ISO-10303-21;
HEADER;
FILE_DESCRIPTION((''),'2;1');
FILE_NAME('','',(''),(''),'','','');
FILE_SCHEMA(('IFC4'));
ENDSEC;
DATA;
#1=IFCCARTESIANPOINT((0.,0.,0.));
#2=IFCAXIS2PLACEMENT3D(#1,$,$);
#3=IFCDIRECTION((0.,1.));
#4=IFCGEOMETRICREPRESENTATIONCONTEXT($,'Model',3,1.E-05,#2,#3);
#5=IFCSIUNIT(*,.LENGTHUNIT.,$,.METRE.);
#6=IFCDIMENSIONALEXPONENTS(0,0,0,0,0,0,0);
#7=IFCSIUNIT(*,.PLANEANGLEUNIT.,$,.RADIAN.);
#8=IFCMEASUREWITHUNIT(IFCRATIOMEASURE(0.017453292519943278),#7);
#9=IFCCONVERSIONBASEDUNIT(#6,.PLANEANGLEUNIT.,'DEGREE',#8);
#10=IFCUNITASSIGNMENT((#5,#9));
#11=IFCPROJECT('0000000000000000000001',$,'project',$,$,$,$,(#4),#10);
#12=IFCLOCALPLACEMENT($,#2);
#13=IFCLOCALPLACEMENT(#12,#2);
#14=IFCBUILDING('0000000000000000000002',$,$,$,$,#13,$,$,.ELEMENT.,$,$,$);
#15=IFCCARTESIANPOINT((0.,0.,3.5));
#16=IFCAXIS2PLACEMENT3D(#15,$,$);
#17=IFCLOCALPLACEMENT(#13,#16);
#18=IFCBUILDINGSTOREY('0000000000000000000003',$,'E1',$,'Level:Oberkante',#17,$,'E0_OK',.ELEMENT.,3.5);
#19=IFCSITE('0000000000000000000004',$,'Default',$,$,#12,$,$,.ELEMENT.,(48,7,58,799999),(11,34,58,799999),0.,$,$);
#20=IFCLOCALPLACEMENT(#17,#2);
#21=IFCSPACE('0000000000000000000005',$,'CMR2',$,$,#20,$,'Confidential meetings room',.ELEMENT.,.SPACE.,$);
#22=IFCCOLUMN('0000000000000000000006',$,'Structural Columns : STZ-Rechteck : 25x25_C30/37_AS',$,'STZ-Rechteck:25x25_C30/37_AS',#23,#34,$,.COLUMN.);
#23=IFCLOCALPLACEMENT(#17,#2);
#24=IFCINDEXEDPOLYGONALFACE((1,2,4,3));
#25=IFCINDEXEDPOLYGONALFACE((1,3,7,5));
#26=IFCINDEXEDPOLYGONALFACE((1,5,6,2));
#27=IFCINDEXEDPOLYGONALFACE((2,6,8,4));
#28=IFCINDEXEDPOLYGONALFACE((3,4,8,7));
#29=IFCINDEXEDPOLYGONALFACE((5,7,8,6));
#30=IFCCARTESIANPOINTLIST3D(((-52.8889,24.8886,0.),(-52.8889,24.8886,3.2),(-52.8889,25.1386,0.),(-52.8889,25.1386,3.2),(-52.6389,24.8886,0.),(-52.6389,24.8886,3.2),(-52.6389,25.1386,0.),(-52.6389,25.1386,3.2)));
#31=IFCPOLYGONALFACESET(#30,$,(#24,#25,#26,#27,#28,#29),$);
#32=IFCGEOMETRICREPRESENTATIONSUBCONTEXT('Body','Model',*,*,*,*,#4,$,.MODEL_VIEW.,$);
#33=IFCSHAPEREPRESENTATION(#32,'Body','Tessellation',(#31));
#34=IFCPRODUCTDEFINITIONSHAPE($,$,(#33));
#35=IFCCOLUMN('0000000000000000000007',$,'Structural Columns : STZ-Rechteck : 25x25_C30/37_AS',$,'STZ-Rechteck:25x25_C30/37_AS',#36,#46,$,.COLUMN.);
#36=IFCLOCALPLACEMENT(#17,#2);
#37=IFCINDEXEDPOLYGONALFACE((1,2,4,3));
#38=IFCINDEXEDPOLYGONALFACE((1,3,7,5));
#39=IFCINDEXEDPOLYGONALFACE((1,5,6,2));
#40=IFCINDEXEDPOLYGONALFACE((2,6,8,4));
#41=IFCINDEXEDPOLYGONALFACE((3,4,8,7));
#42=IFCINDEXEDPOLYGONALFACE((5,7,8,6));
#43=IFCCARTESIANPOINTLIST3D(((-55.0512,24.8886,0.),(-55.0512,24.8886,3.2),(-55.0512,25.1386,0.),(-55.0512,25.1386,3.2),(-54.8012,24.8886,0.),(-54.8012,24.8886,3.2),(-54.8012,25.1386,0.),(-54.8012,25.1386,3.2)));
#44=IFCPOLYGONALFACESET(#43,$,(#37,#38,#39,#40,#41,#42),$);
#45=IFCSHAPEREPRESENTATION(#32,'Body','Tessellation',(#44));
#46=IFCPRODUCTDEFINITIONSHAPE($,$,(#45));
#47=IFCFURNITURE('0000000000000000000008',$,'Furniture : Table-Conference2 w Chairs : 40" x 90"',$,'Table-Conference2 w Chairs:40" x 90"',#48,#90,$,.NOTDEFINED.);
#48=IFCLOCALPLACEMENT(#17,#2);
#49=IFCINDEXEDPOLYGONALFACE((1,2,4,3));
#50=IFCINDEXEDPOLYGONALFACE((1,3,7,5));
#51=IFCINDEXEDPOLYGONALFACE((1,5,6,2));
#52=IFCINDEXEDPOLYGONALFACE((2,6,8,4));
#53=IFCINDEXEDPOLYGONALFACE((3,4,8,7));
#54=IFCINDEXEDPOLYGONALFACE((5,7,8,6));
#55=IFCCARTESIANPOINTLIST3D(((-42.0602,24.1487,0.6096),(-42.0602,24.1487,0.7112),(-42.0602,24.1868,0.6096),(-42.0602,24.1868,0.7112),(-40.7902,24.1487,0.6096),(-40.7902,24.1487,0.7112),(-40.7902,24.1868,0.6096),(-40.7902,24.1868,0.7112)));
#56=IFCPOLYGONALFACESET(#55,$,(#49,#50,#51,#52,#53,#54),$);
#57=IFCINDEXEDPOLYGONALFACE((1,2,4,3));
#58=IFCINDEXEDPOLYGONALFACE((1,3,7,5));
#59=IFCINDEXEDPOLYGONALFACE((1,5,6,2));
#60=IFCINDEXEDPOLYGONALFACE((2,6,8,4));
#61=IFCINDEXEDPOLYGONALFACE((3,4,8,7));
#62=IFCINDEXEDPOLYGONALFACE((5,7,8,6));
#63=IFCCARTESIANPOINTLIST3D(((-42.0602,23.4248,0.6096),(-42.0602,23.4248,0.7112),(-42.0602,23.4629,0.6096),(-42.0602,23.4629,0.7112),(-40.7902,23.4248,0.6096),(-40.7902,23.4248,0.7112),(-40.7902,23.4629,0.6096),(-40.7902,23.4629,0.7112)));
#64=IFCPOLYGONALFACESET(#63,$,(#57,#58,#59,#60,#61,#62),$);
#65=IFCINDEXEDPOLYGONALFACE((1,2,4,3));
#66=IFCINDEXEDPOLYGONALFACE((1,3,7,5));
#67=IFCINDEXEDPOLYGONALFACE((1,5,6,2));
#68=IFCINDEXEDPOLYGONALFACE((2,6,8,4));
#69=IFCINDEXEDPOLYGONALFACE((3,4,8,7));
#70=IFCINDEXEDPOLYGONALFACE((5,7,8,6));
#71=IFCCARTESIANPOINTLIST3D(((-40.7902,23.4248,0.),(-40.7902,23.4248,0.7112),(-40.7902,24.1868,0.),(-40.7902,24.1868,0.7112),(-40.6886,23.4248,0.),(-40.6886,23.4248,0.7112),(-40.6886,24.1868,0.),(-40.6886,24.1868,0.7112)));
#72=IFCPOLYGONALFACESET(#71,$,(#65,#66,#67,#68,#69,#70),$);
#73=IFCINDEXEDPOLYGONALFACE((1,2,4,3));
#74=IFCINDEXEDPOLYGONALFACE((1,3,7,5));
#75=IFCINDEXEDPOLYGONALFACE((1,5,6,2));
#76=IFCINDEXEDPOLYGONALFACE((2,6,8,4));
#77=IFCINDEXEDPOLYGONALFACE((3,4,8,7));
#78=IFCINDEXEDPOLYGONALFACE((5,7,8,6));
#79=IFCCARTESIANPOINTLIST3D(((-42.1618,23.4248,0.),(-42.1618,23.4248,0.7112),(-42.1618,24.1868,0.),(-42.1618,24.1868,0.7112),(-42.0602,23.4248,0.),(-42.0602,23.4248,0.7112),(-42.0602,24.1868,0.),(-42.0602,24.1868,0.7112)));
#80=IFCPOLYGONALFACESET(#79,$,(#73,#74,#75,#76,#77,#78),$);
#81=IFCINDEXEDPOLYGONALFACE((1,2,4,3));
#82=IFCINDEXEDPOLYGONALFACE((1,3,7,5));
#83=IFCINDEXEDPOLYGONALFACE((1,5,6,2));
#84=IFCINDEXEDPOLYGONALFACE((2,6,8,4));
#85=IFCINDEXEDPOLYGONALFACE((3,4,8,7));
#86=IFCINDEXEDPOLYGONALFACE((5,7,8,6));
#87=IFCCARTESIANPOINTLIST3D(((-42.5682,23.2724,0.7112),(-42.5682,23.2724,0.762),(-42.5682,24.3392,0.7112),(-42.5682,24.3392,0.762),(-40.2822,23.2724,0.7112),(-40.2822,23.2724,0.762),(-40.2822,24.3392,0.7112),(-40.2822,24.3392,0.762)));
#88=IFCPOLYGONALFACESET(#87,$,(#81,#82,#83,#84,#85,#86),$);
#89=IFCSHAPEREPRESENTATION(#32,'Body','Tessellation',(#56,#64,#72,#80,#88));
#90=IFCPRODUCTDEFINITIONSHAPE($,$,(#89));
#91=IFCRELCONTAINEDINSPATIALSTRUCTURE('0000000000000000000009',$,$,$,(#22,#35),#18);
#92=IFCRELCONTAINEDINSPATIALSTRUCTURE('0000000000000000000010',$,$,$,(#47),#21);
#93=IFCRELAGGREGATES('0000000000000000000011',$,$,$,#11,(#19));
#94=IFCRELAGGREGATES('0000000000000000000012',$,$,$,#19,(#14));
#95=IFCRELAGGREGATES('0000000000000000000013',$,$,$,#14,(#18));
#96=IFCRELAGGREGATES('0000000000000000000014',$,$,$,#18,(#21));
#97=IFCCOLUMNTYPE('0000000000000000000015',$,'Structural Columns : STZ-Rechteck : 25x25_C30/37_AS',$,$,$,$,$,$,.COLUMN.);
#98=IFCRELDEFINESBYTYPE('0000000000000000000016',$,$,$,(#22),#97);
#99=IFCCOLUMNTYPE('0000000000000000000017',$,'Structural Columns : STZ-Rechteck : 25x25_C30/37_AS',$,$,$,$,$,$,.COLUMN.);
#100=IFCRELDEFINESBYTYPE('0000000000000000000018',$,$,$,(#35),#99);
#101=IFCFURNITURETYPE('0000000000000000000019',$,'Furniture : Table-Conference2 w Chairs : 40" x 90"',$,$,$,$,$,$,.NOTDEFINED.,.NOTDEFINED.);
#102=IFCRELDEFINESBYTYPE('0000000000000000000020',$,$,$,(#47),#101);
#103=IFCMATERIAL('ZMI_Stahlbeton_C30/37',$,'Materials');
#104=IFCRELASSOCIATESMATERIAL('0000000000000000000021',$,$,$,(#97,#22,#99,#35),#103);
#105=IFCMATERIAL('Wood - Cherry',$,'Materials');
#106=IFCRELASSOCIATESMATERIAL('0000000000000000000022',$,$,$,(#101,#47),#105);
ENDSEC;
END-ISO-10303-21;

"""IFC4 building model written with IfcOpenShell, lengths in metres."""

from ifc_helpers import new_model, entity, si_unit, converted_unit, direction, frame, origin, place, context, subcontext, project, spatial, indexed_curve, outline, extrude, source, transform, mapped, material, type_object, type_shapes, element, save


model = new_model("IFC4")

# Units and contexts
model_context = context("Model", 3, precision=1e-05, world=origin(), true_north=direction((0.0, 1.0)))
body_context = subcontext(model_context, "Body", "Model", "MODEL_VIEW")
ifc_project = project(units=[si_unit("LENGTHUNIT", "METRE"), converted_unit("PLANEANGLEUNIT", "DEGREE", entity("IfcRatioMeasure", 0.017453292519943278), si_unit("PLANEANGLEUNIT", "RADIAN"), dimensions=[0, 0, 0, 0, 0, 0, 0])], contexts=[model_context])

# Site, building, storey
site_placement = place(None, origin())
site = spatial("IfcSite", under=ifc_project, at=site_placement, Name="Default", CompositionType="ELEMENT", RefLatitude=(48, 7, 58, 799999), RefLongitude=(11, 34, 58, 799999), RefElevation=0.0)
building_placement = place(site_placement, origin())
building = spatial("IfcBuilding", under=site, at=building_placement, CompositionType="ELEMENT")
storey_placement = place(building_placement, frame((0.0, 0.0, 3.5)))
storey = spatial("IfcBuildingStorey", under=building, at=storey_placement, Name="E1", ObjectType="Level:Oberkante", LongName="E0_OK", CompositionType="ELEMENT", Elevation=3.5)

# Columns
ifc_material_1 = material(Name="ZMI_Stahlbeton_C30/37", Category="Materials")
column_type_1 = type_object("IfcColumnType", Name="Structural Columns : STZ-Rechteck : 25x25_C30/37_AS", PredefinedType="COLUMN", material=ifc_material_1)
shared_shape_1 = source(origin(), body_context, "Body", "SweptSolid", [
    extrude(outline(indexed_curve([(-0.125, -0.125), (0.125, -0.125), (0.125, 0.125), (-0.125, 0.125), (-0.125, -0.125)], self_intersect=False)), frame((-52.7639, 25.0136, 3.5), z_axis=(0.0, 0.0, 1.0), x_axis=(0.0, -1.0, 0.0)), (0.0, 0.0, 1.0), 3.2),
])
type_shapes(column_type_1, [shared_shape_1])
column_1_placement = place(storey_placement, frame((0.0, 0.0, -3.5)))
element("IfcColumn", 1, at=column_1_placement, inside=storey, type_object=column_type_1, material=ifc_material_1, Name="Structural Columns : STZ-Rechteck : 25x25_C30/37_AS", ObjectType="STZ-Rechteck:25x25_C30/37_AS", PredefinedType="COLUMN", context=body_context, shape_type="MappedRepresentation", body=[
    mapped(shared_shape_1, transform((0.0, 0.0, 0.0), scale=1.0)),
])
column_type_2 = type_object("IfcColumnType", Name="Structural Columns : STZ-Rechteck : 25x25_C30/37_AS", PredefinedType="COLUMN", material=ifc_material_1)
shared_shape_2 = source(origin(), body_context, "Body", "SweptSolid", [
    extrude(outline(indexed_curve([(-0.125, -0.125), (0.125, -0.125), (0.125, 0.125), (-0.125, 0.125), (-0.125, -0.125)], self_intersect=False)), frame((-54.9262, 25.0136, 3.5), z_axis=(0.0, 0.0, 1.0), x_axis=(0.0, -1.0, 0.0)), (0.0, 0.0, 1.0), 3.2),
])
type_shapes(column_type_2, [shared_shape_2])
column_2_placement = place(storey_placement, frame((0.0, 0.0, -3.5)))
element("IfcColumn", 2, at=column_2_placement, inside=storey, type_object=column_type_2, material=ifc_material_1, Name="Structural Columns : STZ-Rechteck : 25x25_C30/37_AS", ObjectType="STZ-Rechteck:25x25_C30/37_AS", PredefinedType="COLUMN", context=body_context, shape_type="MappedRepresentation", body=[
    mapped(shared_shape_2, transform((0.0, 0.0, 0.0), scale=1.0)),
])

# Shared definitions
space_placement = place(storey_placement, origin())
space = spatial("IfcSpace", under=storey, at=space_placement, Name="CMR2", LongName="Confidential meetings room", CompositionType="ELEMENT", PredefinedType="SPACE")

# Furniture
ifc_material_2 = material(Name="Wood - Cherry", Category="Materials")
furniture_type_1 = type_object("IfcFurnitureType", Name="Furniture : Table-Conference2 w Chairs : 40\" x 90\"", AssemblyPlace="NOTDEFINED", PredefinedType="NOTDEFINED", material=ifc_material_2)
shared_shape_3 = source(origin(), body_context, "Body", "SweptSolid", [
    extrude(outline(indexed_curve([(-0.635, -0.0191), (0.635, -0.0191), (0.635, 0.0191), (-0.635, 0.0191), (-0.635, -0.0191)], self_intersect=False)), frame((0.0, 0.362, 0.6096), z_axis=(0.0, 0.0, 1.0), x_axis=(-1.0, 0.0, 0.0)), (0.0, 0.0, 1.0), 0.1016),
    extrude(outline(indexed_curve([(-0.019, -0.635), (0.019, -0.635), (0.019, 0.635), (-0.019, 0.635), (-0.019, -0.635)], self_intersect=False)), frame((0.0, -0.362, 0.6096), z_axis=(0.0, 0.0, 1.0), x_axis=(0.0, 1.0, 0.0)), (0.0, 0.0, 1.0), 0.1016),
    extrude(outline(indexed_curve([(-0.381, -0.0508), (0.381, -0.0508), (0.381, 0.0508), (-0.381, 0.0508), (-0.381, -0.0508)], self_intersect=False)), frame((0.6858, 0.0, 0.0), z_axis=(0.0, 0.0, 1.0), x_axis=(0.0, 1.0, 0.0)), (0.0, 0.0, 1.0), 0.7112),
    extrude(outline(indexed_curve([(-0.381, -0.0508), (0.381, -0.0508), (0.381, 0.0508), (-0.381, 0.0508), (-0.381, -0.0508)], self_intersect=False)), frame((-0.6858, 0.0, 0.0), z_axis=(0.0, 0.0, 1.0), x_axis=(0.0, 1.0, 0.0)), (0.0, 0.0, 1.0), 0.7112),
    extrude(outline(indexed_curve([(-0.5334, -1.143), (0.5334, -1.143), (0.5334, 1.143), (-0.5334, 1.143), (-0.5334, -1.143)], self_intersect=False)), frame((0.0, 0.0, 0.7112), z_axis=(0.0, 0.0, 1.0), x_axis=(0.0, 1.0, 0.0)), (0.0, 0.0, 1.0), 0.0508),
])
type_shapes(furniture_type_1, [shared_shape_3])
furniture_1_placement = place(space_placement, frame((-41.4252, 23.8058, 0.0)))
element("IfcFurniture", 3, at=furniture_1_placement, inside=space, type_object=furniture_type_1, material=ifc_material_2, Name="Furniture : Table-Conference2 w Chairs : 40\" x 90\"", ObjectType="Table-Conference2 w Chairs:40\" x 90\"", PredefinedType="NOTDEFINED", context=body_context, shape_type="MappedRepresentation", body=[
    mapped(shared_shape_3, transform((0.0, 0.0, 0.0), scale=1.0)),
])

save(model, "model.ifc")
